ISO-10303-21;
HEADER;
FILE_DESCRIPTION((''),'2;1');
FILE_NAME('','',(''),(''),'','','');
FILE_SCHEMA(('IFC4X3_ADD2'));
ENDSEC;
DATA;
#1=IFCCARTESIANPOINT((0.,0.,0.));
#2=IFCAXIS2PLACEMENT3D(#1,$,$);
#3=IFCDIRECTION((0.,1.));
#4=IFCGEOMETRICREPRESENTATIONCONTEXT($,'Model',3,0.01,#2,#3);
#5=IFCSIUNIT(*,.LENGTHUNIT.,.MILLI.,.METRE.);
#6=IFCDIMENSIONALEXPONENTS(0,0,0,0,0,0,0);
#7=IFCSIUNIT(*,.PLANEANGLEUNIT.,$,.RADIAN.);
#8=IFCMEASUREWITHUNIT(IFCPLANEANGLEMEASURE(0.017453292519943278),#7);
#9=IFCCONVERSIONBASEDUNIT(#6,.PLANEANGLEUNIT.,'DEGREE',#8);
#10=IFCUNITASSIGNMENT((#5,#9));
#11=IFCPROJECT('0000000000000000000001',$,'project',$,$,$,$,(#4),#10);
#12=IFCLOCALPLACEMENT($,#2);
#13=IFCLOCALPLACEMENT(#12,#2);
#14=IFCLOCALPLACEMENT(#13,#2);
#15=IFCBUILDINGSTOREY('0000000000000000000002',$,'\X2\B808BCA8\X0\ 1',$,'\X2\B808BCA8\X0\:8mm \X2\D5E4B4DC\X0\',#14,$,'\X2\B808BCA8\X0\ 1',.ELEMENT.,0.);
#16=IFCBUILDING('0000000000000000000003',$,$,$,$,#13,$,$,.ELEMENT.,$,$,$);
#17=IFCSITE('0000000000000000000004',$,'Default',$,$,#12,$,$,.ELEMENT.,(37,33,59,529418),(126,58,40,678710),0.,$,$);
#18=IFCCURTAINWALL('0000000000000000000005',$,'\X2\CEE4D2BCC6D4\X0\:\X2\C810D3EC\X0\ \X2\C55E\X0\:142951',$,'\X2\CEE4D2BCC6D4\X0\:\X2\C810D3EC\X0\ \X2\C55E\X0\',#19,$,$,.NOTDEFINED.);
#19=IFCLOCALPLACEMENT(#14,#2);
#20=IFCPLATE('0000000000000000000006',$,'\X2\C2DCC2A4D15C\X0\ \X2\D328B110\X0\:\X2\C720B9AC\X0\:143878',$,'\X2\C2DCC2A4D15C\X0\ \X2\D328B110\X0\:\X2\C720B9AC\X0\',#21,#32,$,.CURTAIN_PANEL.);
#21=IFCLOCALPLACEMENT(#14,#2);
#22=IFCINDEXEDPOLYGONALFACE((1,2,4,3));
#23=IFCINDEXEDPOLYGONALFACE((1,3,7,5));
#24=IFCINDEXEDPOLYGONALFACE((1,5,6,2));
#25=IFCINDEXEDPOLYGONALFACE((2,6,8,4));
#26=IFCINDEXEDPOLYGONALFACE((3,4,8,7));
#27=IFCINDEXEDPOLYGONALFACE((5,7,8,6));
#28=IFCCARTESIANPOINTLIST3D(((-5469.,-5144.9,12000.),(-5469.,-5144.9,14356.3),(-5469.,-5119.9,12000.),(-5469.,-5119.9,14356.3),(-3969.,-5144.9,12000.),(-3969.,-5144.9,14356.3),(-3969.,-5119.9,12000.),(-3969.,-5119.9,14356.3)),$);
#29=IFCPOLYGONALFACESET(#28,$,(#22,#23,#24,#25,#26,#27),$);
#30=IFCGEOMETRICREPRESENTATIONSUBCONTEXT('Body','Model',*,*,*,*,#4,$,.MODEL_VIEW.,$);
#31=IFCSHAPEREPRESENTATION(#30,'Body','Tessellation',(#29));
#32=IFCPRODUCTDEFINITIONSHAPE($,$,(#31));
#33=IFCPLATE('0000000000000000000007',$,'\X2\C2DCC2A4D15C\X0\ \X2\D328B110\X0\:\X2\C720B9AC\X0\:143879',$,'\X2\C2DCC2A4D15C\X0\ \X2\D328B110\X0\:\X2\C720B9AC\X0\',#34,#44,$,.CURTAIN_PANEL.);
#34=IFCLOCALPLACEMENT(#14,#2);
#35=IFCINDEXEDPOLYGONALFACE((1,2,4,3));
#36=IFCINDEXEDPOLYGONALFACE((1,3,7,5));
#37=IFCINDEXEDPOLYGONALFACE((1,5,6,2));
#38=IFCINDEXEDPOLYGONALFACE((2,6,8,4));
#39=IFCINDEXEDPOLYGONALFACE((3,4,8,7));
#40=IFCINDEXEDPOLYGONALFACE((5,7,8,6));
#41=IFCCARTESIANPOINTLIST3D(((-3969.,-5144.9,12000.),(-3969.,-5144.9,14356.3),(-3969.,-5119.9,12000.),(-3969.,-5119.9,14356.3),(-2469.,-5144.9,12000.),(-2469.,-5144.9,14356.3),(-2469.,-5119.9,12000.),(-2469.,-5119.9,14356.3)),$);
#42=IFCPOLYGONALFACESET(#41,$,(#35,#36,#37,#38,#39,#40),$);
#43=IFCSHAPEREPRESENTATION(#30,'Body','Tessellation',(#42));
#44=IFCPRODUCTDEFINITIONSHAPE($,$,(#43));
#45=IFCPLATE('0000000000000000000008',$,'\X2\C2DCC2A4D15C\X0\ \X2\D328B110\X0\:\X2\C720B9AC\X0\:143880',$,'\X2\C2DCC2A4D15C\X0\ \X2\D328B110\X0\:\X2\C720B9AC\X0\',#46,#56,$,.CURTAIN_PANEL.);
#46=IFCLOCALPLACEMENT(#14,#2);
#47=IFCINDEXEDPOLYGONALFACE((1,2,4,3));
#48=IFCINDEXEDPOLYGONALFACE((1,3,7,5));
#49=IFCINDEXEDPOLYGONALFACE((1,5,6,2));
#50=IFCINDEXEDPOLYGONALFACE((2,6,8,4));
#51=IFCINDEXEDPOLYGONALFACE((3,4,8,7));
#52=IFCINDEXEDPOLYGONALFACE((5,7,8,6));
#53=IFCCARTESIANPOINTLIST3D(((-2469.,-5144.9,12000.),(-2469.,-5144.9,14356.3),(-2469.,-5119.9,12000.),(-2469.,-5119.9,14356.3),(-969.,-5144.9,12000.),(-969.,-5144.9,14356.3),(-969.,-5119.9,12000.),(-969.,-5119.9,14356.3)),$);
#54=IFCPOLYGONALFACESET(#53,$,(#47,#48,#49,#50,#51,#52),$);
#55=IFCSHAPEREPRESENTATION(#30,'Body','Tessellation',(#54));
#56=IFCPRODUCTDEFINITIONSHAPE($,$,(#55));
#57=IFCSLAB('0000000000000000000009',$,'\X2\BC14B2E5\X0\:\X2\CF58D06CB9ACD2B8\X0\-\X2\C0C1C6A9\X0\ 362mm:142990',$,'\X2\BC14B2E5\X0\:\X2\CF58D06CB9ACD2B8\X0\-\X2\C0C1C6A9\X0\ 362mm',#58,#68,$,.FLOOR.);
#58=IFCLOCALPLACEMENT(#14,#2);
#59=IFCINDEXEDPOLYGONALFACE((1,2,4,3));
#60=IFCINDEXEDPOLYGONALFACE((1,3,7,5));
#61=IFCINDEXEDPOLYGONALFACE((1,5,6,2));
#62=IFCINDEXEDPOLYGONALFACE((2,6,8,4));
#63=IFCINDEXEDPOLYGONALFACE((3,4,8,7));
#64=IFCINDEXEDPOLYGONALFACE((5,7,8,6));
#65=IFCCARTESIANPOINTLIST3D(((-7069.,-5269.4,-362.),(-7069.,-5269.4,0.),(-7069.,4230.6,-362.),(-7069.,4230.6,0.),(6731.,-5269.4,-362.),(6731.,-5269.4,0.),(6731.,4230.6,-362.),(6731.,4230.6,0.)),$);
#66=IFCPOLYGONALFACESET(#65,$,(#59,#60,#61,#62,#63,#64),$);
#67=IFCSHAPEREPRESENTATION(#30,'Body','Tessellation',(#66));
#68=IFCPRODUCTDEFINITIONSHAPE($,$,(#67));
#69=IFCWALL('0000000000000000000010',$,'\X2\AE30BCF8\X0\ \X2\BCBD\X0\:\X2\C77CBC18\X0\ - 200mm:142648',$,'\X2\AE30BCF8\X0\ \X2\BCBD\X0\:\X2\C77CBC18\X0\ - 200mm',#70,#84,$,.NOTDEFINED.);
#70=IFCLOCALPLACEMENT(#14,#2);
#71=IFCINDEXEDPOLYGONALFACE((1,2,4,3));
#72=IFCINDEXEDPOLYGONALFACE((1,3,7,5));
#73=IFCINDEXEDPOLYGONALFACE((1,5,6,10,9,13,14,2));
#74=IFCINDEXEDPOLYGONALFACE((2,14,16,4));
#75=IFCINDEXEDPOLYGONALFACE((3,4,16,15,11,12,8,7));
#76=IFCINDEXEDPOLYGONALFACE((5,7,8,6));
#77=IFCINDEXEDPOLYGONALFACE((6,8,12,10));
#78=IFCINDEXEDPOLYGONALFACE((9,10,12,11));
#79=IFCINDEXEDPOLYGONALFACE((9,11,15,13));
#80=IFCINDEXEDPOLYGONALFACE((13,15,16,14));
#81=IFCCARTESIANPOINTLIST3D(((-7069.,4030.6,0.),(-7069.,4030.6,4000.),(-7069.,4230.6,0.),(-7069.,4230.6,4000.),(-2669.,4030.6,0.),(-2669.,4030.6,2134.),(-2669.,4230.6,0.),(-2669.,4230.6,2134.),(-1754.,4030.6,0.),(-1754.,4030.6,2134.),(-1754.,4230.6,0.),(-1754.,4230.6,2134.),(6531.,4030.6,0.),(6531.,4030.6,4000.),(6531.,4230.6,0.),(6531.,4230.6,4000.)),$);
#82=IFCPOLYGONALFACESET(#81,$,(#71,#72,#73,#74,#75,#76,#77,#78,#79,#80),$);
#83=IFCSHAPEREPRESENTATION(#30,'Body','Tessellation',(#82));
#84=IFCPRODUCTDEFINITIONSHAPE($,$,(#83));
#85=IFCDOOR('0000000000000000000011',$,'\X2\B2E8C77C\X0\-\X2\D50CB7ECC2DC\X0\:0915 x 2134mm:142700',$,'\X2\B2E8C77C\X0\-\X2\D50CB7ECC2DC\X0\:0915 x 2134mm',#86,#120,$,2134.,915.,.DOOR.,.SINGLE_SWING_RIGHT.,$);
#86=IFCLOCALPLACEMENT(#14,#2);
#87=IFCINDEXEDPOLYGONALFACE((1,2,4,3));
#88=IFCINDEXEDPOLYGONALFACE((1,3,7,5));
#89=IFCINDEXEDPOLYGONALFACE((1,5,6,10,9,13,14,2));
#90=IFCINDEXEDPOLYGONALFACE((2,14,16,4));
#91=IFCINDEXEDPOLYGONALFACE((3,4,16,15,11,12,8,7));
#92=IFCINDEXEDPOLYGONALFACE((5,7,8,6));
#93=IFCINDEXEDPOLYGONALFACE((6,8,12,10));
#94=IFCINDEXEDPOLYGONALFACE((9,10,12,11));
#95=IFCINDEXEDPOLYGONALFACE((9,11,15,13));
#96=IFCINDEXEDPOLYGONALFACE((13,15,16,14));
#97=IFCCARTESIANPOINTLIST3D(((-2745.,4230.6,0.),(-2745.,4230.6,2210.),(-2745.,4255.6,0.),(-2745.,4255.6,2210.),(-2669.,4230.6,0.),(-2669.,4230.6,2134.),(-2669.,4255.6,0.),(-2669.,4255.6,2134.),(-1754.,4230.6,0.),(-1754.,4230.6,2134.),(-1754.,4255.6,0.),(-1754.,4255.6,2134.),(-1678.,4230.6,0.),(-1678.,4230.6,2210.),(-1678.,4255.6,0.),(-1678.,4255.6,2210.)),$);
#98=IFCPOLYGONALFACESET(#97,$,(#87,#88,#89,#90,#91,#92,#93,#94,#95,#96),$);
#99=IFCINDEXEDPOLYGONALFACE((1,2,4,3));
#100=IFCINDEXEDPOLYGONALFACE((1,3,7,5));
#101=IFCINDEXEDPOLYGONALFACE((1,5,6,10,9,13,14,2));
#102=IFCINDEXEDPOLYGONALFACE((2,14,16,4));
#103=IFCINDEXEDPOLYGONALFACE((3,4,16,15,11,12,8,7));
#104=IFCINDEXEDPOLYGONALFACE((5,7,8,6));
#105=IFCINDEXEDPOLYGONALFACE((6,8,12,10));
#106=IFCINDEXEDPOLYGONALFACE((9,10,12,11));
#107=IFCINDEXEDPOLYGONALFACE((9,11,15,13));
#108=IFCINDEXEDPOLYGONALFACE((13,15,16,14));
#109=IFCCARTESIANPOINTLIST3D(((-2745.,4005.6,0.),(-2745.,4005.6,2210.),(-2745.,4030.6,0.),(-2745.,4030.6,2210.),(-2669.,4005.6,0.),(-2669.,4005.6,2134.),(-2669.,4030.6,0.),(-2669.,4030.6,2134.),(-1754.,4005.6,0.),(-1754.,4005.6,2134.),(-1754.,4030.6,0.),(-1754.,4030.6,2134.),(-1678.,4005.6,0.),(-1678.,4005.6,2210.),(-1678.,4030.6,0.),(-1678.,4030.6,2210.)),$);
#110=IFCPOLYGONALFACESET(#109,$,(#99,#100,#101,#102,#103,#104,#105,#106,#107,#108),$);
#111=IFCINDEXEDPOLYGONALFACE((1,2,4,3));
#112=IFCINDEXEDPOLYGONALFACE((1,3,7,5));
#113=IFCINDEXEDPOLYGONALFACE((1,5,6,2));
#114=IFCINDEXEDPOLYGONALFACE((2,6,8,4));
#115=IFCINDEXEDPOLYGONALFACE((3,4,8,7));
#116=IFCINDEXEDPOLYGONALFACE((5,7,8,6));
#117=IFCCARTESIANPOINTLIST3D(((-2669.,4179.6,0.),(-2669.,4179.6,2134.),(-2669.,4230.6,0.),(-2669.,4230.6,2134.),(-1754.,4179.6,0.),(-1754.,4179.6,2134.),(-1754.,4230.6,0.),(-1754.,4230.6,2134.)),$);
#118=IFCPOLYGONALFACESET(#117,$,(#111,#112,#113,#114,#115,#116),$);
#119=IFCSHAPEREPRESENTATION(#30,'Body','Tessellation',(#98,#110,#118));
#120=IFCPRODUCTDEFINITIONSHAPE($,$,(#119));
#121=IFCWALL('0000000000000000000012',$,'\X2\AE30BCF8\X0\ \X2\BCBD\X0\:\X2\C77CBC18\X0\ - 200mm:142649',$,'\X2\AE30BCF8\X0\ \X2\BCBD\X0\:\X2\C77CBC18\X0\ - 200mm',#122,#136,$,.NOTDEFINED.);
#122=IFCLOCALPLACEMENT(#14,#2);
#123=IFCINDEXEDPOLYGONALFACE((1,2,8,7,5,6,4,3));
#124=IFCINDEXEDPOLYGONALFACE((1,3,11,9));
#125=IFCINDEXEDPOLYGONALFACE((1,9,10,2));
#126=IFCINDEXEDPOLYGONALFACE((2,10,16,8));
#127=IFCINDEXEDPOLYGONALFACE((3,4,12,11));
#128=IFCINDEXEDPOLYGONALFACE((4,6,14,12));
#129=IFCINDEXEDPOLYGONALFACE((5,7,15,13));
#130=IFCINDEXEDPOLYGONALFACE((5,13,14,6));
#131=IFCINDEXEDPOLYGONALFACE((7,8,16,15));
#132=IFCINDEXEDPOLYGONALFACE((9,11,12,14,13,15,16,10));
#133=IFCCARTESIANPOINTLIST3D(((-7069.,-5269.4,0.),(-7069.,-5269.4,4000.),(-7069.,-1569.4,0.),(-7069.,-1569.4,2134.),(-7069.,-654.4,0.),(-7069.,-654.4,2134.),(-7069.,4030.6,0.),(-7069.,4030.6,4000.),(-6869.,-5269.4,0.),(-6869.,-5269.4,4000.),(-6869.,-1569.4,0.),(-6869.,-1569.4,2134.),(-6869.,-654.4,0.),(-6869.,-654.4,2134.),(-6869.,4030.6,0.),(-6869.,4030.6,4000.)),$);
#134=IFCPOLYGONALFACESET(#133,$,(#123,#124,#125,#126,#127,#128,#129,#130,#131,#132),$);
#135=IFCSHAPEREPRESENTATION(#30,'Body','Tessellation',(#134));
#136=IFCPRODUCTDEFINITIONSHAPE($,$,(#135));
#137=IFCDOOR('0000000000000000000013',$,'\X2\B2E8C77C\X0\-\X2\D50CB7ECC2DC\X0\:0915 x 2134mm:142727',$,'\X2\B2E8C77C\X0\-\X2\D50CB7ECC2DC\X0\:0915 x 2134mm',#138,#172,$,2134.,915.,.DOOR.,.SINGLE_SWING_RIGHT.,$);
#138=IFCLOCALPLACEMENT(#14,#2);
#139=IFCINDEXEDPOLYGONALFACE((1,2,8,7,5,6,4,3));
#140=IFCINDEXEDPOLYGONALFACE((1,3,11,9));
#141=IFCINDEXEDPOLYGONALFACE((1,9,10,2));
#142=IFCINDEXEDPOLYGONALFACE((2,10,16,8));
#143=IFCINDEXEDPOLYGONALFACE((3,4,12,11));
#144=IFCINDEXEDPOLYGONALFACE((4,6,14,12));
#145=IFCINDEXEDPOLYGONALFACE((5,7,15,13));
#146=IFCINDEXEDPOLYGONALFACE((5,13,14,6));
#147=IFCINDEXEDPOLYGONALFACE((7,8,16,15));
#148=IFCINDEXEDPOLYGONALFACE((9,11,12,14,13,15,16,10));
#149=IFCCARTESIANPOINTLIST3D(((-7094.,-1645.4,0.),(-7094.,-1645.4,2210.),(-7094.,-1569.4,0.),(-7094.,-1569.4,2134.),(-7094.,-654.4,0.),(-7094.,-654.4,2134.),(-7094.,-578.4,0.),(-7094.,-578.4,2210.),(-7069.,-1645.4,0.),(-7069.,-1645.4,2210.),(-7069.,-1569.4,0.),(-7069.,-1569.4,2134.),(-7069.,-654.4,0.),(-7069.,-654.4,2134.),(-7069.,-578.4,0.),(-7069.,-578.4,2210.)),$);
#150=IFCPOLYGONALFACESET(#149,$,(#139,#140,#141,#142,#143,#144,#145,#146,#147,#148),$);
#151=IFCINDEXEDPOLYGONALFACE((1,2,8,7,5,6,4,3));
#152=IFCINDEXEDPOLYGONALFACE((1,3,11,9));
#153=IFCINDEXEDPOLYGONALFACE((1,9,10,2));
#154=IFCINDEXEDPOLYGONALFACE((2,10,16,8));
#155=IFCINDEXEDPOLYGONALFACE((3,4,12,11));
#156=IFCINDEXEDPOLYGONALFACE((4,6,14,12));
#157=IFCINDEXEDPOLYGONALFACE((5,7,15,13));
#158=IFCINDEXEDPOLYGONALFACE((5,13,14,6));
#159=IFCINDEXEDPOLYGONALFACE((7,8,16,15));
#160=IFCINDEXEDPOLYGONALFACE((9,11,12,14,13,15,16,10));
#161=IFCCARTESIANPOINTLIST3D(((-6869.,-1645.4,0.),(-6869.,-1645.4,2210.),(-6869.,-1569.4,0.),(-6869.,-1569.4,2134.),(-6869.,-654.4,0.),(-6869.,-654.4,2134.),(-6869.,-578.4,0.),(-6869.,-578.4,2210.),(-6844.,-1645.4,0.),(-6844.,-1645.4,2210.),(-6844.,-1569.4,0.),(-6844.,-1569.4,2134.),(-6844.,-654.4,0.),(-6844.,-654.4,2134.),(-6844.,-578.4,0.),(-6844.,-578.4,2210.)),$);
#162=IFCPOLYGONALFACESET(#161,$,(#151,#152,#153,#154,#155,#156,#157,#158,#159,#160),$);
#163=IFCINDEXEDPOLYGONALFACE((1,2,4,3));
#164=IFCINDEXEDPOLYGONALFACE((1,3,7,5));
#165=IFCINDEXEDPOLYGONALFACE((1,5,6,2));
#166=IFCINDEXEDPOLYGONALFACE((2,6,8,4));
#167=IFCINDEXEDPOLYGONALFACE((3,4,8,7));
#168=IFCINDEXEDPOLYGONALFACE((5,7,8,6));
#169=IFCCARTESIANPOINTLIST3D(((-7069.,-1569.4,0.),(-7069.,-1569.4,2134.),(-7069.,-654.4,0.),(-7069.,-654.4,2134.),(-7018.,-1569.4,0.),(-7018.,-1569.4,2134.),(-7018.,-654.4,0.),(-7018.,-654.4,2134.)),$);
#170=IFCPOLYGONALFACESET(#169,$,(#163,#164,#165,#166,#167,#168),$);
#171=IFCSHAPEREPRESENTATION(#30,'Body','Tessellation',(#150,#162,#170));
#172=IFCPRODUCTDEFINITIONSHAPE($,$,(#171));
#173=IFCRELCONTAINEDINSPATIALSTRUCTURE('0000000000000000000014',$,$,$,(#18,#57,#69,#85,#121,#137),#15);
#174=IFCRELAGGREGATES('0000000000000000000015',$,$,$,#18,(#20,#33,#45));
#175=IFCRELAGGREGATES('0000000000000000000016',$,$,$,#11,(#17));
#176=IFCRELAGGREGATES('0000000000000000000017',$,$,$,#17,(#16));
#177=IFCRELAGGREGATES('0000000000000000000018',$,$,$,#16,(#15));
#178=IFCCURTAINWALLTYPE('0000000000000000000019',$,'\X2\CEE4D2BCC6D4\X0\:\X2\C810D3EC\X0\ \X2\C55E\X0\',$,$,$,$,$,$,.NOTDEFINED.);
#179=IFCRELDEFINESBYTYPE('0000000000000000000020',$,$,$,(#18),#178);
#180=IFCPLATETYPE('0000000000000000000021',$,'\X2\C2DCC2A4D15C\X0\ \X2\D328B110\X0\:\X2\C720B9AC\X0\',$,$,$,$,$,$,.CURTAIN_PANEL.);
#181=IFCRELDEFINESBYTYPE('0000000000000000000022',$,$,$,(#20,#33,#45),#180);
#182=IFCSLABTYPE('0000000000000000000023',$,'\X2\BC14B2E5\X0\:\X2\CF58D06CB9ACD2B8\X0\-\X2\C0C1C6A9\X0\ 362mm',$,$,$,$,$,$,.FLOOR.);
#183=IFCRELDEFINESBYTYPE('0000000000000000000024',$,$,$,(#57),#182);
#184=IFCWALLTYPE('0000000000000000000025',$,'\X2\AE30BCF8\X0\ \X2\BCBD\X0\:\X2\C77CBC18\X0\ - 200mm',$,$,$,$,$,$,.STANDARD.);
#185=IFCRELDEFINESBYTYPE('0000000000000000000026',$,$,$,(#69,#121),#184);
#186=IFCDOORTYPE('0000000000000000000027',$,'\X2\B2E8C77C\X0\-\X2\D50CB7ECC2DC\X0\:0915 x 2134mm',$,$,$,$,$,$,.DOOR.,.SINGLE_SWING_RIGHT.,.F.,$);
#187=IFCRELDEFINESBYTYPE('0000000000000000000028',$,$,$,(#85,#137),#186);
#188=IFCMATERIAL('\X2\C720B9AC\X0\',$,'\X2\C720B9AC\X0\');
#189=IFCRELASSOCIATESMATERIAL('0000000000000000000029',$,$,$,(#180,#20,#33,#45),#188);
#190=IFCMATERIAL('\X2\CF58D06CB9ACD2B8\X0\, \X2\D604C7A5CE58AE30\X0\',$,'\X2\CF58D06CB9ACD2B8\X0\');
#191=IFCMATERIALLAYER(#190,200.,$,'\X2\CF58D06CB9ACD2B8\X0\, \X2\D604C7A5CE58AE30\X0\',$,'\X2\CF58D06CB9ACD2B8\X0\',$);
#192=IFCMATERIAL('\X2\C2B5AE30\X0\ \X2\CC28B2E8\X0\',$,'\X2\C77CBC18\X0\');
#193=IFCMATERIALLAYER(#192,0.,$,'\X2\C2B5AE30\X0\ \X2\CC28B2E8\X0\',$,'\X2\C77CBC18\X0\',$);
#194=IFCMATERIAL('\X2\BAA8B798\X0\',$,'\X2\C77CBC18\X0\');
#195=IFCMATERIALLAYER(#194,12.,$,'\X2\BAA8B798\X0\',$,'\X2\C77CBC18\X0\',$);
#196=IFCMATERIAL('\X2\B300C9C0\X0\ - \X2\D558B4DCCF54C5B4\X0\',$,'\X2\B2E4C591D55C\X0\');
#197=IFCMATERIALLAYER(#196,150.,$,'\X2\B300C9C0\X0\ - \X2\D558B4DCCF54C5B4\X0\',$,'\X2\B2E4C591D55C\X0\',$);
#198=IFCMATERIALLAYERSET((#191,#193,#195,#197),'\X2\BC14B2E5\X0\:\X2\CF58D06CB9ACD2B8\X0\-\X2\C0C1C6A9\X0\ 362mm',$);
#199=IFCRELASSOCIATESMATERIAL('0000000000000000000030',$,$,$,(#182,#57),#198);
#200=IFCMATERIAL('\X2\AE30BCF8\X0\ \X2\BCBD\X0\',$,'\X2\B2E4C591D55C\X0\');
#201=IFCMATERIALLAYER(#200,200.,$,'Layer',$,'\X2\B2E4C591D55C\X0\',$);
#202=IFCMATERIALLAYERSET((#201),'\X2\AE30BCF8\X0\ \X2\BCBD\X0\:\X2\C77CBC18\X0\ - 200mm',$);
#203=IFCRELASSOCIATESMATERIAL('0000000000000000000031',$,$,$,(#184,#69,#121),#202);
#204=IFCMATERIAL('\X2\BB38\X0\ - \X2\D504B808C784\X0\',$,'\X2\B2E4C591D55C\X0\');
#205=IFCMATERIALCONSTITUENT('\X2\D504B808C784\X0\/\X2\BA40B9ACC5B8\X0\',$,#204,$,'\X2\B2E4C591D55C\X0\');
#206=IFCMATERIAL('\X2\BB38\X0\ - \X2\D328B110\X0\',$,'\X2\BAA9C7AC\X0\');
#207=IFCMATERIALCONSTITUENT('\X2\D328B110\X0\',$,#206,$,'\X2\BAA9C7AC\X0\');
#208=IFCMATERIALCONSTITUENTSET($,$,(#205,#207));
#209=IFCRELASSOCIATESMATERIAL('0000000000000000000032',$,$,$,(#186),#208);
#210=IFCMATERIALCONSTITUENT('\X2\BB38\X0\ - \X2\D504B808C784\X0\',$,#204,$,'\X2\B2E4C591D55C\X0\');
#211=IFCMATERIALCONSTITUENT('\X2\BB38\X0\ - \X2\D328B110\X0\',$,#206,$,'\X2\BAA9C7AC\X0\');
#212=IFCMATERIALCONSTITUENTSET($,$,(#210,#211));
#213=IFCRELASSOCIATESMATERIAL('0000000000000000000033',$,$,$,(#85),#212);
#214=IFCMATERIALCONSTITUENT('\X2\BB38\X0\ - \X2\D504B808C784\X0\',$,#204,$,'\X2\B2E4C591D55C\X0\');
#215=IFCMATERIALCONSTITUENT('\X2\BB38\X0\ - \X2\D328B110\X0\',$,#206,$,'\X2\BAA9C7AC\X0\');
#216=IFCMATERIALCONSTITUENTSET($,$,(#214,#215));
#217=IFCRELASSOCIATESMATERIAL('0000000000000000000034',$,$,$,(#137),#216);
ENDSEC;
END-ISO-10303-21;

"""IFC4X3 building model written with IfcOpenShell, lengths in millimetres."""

from ifc_helpers import new_model, entity, si_unit, converted_unit, direction, frame, frame_2d, origin, origin_2d_with_axis, place, context, subcontext, project, spatial, polyline, rectangle, outline, extrude, source, transform, mapped, material, layer, layer_set, layer_usage, constituent, constituent_set, type_object, type_shapes, element, fill, aggregate, save


model = new_model("IFC4X3")

# Units and contexts
model_context = context("Model", 3, precision=0.01, world=origin(), true_north=direction((0.0, 1.0)))
body_context = subcontext(model_context, "Body", "Model", "MODEL_VIEW")
ifc_project = project(units=[si_unit("LENGTHUNIT", "METRE", prefix="MILLI"), converted_unit("PLANEANGLEUNIT", "DEGREE", entity("IfcPlaneAngleMeasure", 0.017453292519943278), si_unit("PLANEANGLEUNIT", "RADIAN"), dimensions=[0, 0, 0, 0, 0, 0, 0])], contexts=[model_context])

# Site, building, storey
site_placement = place(None, origin())
site = spatial("IfcSite", under=ifc_project, at=site_placement, Name="Default", CompositionType="ELEMENT", RefLatitude=(37, 33, 59, 529418), RefLongitude=(126, 58, 40, 678710), RefElevation=0.0)
building_placement = place(site_placement, origin())
building = spatial("IfcBuilding", under=site, at=building_placement, CompositionType="ELEMENT")
storey_placement = place(building_placement, origin())
storey = spatial("IfcBuildingStorey", under=building, at=storey_placement, Name="레벨 1", ObjectType="레벨:8mm 헤드", LongName="레벨 1", CompositionType="ELEMENT", Elevation=0.0)

# Curtain wall, plates
curtain_wall_type = type_object("IfcCurtainWallType", Name="커튼월:점포 앞", PredefinedType="NOTDEFINED")
curtain_wall_placement = place(storey_placement, origin())
curtain_wall = element("IfcCurtainWall", 1, at=curtain_wall_placement, inside=storey, type_object=curtain_wall_type, Name="커튼월:점포 앞:142951", ObjectType="커튼월:점포 앞", PredefinedType="NOTDEFINED")
ifc_material_1 = material(Name="유리", Category="유리")
plate_type_1 = type_object("IfcPlateType", Name="시스템 패널:유리", PredefinedType="CURTAIN_PANEL", material=ifc_material_1)
shared_shape_1 = source(origin(), body_context, "Body", "SweptSolid", [
    extrude(rectangle(XDim=25.0, YDim=1500.0, at=origin_2d_with_axis()), frame((750.0, 12.5, 0.0), z_axis=(0.0, 0.0, 1.0), x_axis=(0.0, 1.0, 0.0)), (0.0, 0.0, 1.0), 2356.3),
])
type_shapes(plate_type_1, [shared_shape_1])
plate_1_placement = place(curtain_wall_placement, frame((-5469.0, -5144.9, 12000.0)))
plate_1 = element("IfcPlate", 2, at=plate_1_placement, type_object=plate_type_1, material=ifc_material_1, Name="시스템 패널:유리:143878", ObjectType="시스템 패널:유리", PredefinedType="CURTAIN_PANEL", context=body_context, shape_type="MappedRepresentation", body=[
    mapped(shared_shape_1, transform((0.0, 0.0, 0.0), scale=1.0)),
])
plate_2_placement = place(curtain_wall_placement, frame((-3969.0, -5144.9, 12000.0)))
plate_2 = element("IfcPlate", 3, at=plate_2_placement, type_object=plate_type_1, material=ifc_material_1, Name="시스템 패널:유리:143879", ObjectType="시스템 패널:유리", PredefinedType="CURTAIN_PANEL", context=body_context, shape_type="MappedRepresentation", body=[
    mapped(shared_shape_1, transform((0.0, 0.0, 0.0), scale=1.0)),
])
plate_3_placement = place(curtain_wall_placement, frame((-2469.0, -5144.9, 12000.0)))
plate_3 = element("IfcPlate", 4, at=plate_3_placement, type_object=plate_type_1, material=ifc_material_1, Name="시스템 패널:유리:143880", ObjectType="시스템 패널:유리", PredefinedType="CURTAIN_PANEL", context=body_context, shape_type="MappedRepresentation", body=[
    mapped(shared_shape_1, transform((0.0, 0.0, 0.0), scale=1.0)),
])
aggregate(curtain_wall, [plate_1, plate_2, plate_3])

# Slab
ifc_material_2 = material(Name="콘크리트, 현장치기", Category="콘크리트")
ifc_layer_1 = layer(ifc_material_2, 200.0, Name="콘크리트, 현장치기", Category="콘크리트")
ifc_material_3 = material(Name="습기 차단", Category="일반")
ifc_layer_2 = layer(ifc_material_3, 0.0, Name="습기 차단", Category="일반")
ifc_material_4 = material(Name="모래", Category="일반")
ifc_layer_3 = layer(ifc_material_4, 12.0, Name="모래", Category="일반")
ifc_material_5 = material(Name="대지 - 하드코어", Category="다양한")
ifc_layer_4 = layer(ifc_material_5, 150.0, Name="대지 - 하드코어", Category="다양한")
ifc_layer_set_1 = layer_set([ifc_layer_1, ifc_layer_2, ifc_layer_3, ifc_layer_4], Name="바닥:콘크리트-상용 362mm")
ifc_layer_usage_1 = layer_usage(ifc_layer_set_1, "AXIS3", "POSITIVE", 0.0)
slab_type = type_object("IfcSlabType", Name="바닥:콘크리트-상용 362mm", PredefinedType="FLOOR", material=ifc_layer_set_1)
slab_placement = place(storey_placement, origin())
element("IfcSlab", 5, at=slab_placement, inside=storey, type_object=slab_type, material=ifc_layer_usage_1, Name="바닥:콘크리트-상용 362mm:142990", ObjectType="바닥:콘크리트-상용 362mm", PredefinedType="FLOOR", context=body_context, shape_type="SweptSolid", body=[
    extrude(rectangle(XDim=9500.0, YDim=13800.0, at=origin_2d_with_axis()), frame((-169.0, -519.4, 0.0), z_axis=(0.0, 0.0, -1.0), x_axis=(0.0, 1.0, 0.0)), (0.0, 0.0, 1.0), 362.0),
])

# Walls, openings, doors
ifc_material_6 = material(Name="기본 벽", Category="다양한")
ifc_layer_5 = layer(ifc_material_6, 200.0, Name="Layer", Category="다양한")
ifc_layer_set_2 = layer_set([ifc_layer_5], Name="기본 벽:일반 - 200mm")
wall_type = type_object("IfcWallType", Name="기본 벽:일반 - 200mm", PredefinedType="STANDARD", material=ifc_layer_set_2)
wall_1_placement = place(storey_placement, frame((-7069.0, 4130.6, 0.0)))
wall_1 = element("IfcWall", 6, at=wall_1_placement, inside=storey, type_object=wall_type, material=ifc_layer_set_2, Name="기본 벽:일반 - 200mm:142648", ObjectType="기본 벽:일반 - 200mm", PredefinedType="NOTDEFINED", context=body_context, shape_type="SweptSolid", body=[
    extrude(rectangle(XDim=13600.0, YDim=200.0, at=frame_2d((6800.0, 0.0), x_axis=(1.0, 0.0))), origin(), (0.0, 0.0, 1.0), 4000.0),
])
opening_1_placement = place(wall_1_placement, frame((4400.0, -100.0, 0.0)))
opening_1 = element("IfcOpeningElement", 7, at=opening_1_placement, cuts=wall_1, PredefinedType="OPENING", context=body_context, shape_type="SweptSolid", body=[
    extrude(rectangle(XDim=915.0, YDim=2134.0, at=frame_2d((1067.0, 457.5), x_axis=(0.0, 1.0))), frame((0.0, 0.0, 0.0), z_axis=(0.0, 1.0, 0.0), x_axis=(0.0, 0.0, 1.0)), (0.0, 0.0, 1.0), 200.0),
])
ifc_material_7 = material(Name="문 - 프레임", Category="다양한")
ifc_constituent_1 = constituent(ifc_material_7, Name="문 - 프레임", Category="다양한")
ifc_material_8 = material(Name="문 - 패널", Category="목재")
ifc_constituent_2 = constituent(ifc_material_8, Name="문 - 패널", Category="목재")
ifc_constituent_set_1 = constituent_set(constituents=[ifc_constituent_1, ifc_constituent_2])
ifc_constituent_3 = constituent(ifc_material_7, Name="프레임/멀리언", Category="다양한")
ifc_constituent_4 = constituent(ifc_material_8, Name="패널", Category="목재")
ifc_constituent_set_2 = constituent_set(constituents=[ifc_constituent_3, ifc_constituent_4])
door_type = type_object("IfcDoorType", Name="단일-플러시:0915 x 2134mm", OperationType="SINGLE_SWING_RIGHT", ParameterTakesPrecedence=False, PredefinedType="DOOR", material=ifc_constituent_set_2)
shared_shape_2 = source(origin(), body_context, "Body", "SweptSolid", [
    extrude(outline(polyline([(-533.5, -1124.0), (533.5, -1124.0), (533.5, 1086.0), (457.5, 1086.0), (457.5, -1048.0), (-457.5, -1048.0), (-457.5, 1086.0), (-533.5, 1086.0), (-533.5, -1124.0)])), frame((457.5, 200.0, 1086.0), z_axis=(0.0, 1.0, 0.0), x_axis=(1.0, 0.0, 0.0)), (0.0, 0.0, 1.0), 25.0),
    extrude(outline(polyline([(-1124.0, -533.5), (1086.0, -533.5), (1086.0, -457.5), (-1048.0, -457.5), (-1048.0, 457.5), (1086.0, 457.5), (1086.0, 533.5), (-1124.0, 533.5), (-1124.0, -533.5)])), frame((457.5, -25.0, 1086.0), z_axis=(0.0, 1.0, 0.0), x_axis=(0.0, 0.0, -1.0)), (0.0, 0.0, 1.0), 25.0),
    extrude(rectangle(XDim=51.0, YDim=915.0, at=frame_2d((0.0, 0.0), x_axis=(1.0, 0.0))), frame((457.5, 174.5, 0.0), z_axis=(0.0, 0.0, 1.0), x_axis=(0.0, 1.0, 0.0)), (0.0, 0.0, 1.0), 2134.0),
])
type_shapes(door_type, [shared_shape_2])
door_1_placement = place(opening_1_placement, origin())
door_1 = element("IfcDoor", 8, at=door_1_placement, inside=storey, type_object=door_type, material=ifc_constituent_set_1, Name="단일-플러시:0915 x 2134mm:142700", ObjectType="단일-플러시:0915 x 2134mm", OperationType="SINGLE_SWING_RIGHT", OverallHeight=2134.0, OverallWidth=915.0, PredefinedType="DOOR", context=body_context, shape_type="MappedRepresentation", body=[
    mapped(shared_shape_2, transform((0.0, 0.0, 0.0), scale=1.0)),
])
fill(opening_1, door_1)
wall_2_placement = place(storey_placement, frame((-6969.0, -5269.4, 0.0), z_axis=(0.0, 0.0, 1.0), x_axis=(0.0, 1.0, 0.0)))
wall_2 = element("IfcWall", 9, at=wall_2_placement, inside=storey, type_object=wall_type, material=ifc_layer_set_2, Name="기본 벽:일반 - 200mm:142649", ObjectType="기본 벽:일반 - 200mm", PredefinedType="NOTDEFINED", context=body_context, shape_type="SweptSolid", body=[
    extrude(rectangle(XDim=9300.0, YDim=200.0, at=frame_2d((4650.0, 0.0), x_axis=(1.0, 0.0))), origin(), (0.0, 0.0, 1.0), 4000.0),
])
opening_2_placement = place(wall_2_placement, frame((3700.0, -100.0, 0.0)))
opening_2 = element("IfcOpeningElement", 10, at=opening_2_placement, cuts=wall_2, PredefinedType="OPENING", context=body_context, shape_type="SweptSolid", body=[
    extrude(rectangle(XDim=915.0, YDim=2134.0, at=frame_2d((1067.0, 457.5), x_axis=(0.0, 1.0))), frame((0.0, 0.0, 0.0), z_axis=(0.0, 1.0, 0.0), x_axis=(0.0, 0.0, 1.0)), (0.0, 0.0, 1.0), 200.0),
])
ifc_constituent_5 = constituent(ifc_material_7, Name="문 - 프레임", Category="다양한")
ifc_constituent_6 = constituent(ifc_material_8, Name="문 - 패널", Category="목재")
ifc_constituent_set_3 = constituent_set(constituents=[ifc_constituent_5, ifc_constituent_6])
door_2_placement = place(opening_2_placement, origin())
door_2 = element("IfcDoor", 11, at=door_2_placement, inside=storey, type_object=door_type, material=ifc_constituent_set_3, Name="단일-플러시:0915 x 2134mm:142727", ObjectType="단일-플러시:0915 x 2134mm", OperationType="SINGLE_SWING_RIGHT", OverallHeight=2134.0, OverallWidth=915.0, PredefinedType="DOOR", context=body_context, shape_type="MappedRepresentation", body=[
    mapped(shared_shape_2, transform((0.0, 0.0, 0.0), scale=1.0)),
])
fill(opening_2, door_2)

save(model, "model.ifc")
